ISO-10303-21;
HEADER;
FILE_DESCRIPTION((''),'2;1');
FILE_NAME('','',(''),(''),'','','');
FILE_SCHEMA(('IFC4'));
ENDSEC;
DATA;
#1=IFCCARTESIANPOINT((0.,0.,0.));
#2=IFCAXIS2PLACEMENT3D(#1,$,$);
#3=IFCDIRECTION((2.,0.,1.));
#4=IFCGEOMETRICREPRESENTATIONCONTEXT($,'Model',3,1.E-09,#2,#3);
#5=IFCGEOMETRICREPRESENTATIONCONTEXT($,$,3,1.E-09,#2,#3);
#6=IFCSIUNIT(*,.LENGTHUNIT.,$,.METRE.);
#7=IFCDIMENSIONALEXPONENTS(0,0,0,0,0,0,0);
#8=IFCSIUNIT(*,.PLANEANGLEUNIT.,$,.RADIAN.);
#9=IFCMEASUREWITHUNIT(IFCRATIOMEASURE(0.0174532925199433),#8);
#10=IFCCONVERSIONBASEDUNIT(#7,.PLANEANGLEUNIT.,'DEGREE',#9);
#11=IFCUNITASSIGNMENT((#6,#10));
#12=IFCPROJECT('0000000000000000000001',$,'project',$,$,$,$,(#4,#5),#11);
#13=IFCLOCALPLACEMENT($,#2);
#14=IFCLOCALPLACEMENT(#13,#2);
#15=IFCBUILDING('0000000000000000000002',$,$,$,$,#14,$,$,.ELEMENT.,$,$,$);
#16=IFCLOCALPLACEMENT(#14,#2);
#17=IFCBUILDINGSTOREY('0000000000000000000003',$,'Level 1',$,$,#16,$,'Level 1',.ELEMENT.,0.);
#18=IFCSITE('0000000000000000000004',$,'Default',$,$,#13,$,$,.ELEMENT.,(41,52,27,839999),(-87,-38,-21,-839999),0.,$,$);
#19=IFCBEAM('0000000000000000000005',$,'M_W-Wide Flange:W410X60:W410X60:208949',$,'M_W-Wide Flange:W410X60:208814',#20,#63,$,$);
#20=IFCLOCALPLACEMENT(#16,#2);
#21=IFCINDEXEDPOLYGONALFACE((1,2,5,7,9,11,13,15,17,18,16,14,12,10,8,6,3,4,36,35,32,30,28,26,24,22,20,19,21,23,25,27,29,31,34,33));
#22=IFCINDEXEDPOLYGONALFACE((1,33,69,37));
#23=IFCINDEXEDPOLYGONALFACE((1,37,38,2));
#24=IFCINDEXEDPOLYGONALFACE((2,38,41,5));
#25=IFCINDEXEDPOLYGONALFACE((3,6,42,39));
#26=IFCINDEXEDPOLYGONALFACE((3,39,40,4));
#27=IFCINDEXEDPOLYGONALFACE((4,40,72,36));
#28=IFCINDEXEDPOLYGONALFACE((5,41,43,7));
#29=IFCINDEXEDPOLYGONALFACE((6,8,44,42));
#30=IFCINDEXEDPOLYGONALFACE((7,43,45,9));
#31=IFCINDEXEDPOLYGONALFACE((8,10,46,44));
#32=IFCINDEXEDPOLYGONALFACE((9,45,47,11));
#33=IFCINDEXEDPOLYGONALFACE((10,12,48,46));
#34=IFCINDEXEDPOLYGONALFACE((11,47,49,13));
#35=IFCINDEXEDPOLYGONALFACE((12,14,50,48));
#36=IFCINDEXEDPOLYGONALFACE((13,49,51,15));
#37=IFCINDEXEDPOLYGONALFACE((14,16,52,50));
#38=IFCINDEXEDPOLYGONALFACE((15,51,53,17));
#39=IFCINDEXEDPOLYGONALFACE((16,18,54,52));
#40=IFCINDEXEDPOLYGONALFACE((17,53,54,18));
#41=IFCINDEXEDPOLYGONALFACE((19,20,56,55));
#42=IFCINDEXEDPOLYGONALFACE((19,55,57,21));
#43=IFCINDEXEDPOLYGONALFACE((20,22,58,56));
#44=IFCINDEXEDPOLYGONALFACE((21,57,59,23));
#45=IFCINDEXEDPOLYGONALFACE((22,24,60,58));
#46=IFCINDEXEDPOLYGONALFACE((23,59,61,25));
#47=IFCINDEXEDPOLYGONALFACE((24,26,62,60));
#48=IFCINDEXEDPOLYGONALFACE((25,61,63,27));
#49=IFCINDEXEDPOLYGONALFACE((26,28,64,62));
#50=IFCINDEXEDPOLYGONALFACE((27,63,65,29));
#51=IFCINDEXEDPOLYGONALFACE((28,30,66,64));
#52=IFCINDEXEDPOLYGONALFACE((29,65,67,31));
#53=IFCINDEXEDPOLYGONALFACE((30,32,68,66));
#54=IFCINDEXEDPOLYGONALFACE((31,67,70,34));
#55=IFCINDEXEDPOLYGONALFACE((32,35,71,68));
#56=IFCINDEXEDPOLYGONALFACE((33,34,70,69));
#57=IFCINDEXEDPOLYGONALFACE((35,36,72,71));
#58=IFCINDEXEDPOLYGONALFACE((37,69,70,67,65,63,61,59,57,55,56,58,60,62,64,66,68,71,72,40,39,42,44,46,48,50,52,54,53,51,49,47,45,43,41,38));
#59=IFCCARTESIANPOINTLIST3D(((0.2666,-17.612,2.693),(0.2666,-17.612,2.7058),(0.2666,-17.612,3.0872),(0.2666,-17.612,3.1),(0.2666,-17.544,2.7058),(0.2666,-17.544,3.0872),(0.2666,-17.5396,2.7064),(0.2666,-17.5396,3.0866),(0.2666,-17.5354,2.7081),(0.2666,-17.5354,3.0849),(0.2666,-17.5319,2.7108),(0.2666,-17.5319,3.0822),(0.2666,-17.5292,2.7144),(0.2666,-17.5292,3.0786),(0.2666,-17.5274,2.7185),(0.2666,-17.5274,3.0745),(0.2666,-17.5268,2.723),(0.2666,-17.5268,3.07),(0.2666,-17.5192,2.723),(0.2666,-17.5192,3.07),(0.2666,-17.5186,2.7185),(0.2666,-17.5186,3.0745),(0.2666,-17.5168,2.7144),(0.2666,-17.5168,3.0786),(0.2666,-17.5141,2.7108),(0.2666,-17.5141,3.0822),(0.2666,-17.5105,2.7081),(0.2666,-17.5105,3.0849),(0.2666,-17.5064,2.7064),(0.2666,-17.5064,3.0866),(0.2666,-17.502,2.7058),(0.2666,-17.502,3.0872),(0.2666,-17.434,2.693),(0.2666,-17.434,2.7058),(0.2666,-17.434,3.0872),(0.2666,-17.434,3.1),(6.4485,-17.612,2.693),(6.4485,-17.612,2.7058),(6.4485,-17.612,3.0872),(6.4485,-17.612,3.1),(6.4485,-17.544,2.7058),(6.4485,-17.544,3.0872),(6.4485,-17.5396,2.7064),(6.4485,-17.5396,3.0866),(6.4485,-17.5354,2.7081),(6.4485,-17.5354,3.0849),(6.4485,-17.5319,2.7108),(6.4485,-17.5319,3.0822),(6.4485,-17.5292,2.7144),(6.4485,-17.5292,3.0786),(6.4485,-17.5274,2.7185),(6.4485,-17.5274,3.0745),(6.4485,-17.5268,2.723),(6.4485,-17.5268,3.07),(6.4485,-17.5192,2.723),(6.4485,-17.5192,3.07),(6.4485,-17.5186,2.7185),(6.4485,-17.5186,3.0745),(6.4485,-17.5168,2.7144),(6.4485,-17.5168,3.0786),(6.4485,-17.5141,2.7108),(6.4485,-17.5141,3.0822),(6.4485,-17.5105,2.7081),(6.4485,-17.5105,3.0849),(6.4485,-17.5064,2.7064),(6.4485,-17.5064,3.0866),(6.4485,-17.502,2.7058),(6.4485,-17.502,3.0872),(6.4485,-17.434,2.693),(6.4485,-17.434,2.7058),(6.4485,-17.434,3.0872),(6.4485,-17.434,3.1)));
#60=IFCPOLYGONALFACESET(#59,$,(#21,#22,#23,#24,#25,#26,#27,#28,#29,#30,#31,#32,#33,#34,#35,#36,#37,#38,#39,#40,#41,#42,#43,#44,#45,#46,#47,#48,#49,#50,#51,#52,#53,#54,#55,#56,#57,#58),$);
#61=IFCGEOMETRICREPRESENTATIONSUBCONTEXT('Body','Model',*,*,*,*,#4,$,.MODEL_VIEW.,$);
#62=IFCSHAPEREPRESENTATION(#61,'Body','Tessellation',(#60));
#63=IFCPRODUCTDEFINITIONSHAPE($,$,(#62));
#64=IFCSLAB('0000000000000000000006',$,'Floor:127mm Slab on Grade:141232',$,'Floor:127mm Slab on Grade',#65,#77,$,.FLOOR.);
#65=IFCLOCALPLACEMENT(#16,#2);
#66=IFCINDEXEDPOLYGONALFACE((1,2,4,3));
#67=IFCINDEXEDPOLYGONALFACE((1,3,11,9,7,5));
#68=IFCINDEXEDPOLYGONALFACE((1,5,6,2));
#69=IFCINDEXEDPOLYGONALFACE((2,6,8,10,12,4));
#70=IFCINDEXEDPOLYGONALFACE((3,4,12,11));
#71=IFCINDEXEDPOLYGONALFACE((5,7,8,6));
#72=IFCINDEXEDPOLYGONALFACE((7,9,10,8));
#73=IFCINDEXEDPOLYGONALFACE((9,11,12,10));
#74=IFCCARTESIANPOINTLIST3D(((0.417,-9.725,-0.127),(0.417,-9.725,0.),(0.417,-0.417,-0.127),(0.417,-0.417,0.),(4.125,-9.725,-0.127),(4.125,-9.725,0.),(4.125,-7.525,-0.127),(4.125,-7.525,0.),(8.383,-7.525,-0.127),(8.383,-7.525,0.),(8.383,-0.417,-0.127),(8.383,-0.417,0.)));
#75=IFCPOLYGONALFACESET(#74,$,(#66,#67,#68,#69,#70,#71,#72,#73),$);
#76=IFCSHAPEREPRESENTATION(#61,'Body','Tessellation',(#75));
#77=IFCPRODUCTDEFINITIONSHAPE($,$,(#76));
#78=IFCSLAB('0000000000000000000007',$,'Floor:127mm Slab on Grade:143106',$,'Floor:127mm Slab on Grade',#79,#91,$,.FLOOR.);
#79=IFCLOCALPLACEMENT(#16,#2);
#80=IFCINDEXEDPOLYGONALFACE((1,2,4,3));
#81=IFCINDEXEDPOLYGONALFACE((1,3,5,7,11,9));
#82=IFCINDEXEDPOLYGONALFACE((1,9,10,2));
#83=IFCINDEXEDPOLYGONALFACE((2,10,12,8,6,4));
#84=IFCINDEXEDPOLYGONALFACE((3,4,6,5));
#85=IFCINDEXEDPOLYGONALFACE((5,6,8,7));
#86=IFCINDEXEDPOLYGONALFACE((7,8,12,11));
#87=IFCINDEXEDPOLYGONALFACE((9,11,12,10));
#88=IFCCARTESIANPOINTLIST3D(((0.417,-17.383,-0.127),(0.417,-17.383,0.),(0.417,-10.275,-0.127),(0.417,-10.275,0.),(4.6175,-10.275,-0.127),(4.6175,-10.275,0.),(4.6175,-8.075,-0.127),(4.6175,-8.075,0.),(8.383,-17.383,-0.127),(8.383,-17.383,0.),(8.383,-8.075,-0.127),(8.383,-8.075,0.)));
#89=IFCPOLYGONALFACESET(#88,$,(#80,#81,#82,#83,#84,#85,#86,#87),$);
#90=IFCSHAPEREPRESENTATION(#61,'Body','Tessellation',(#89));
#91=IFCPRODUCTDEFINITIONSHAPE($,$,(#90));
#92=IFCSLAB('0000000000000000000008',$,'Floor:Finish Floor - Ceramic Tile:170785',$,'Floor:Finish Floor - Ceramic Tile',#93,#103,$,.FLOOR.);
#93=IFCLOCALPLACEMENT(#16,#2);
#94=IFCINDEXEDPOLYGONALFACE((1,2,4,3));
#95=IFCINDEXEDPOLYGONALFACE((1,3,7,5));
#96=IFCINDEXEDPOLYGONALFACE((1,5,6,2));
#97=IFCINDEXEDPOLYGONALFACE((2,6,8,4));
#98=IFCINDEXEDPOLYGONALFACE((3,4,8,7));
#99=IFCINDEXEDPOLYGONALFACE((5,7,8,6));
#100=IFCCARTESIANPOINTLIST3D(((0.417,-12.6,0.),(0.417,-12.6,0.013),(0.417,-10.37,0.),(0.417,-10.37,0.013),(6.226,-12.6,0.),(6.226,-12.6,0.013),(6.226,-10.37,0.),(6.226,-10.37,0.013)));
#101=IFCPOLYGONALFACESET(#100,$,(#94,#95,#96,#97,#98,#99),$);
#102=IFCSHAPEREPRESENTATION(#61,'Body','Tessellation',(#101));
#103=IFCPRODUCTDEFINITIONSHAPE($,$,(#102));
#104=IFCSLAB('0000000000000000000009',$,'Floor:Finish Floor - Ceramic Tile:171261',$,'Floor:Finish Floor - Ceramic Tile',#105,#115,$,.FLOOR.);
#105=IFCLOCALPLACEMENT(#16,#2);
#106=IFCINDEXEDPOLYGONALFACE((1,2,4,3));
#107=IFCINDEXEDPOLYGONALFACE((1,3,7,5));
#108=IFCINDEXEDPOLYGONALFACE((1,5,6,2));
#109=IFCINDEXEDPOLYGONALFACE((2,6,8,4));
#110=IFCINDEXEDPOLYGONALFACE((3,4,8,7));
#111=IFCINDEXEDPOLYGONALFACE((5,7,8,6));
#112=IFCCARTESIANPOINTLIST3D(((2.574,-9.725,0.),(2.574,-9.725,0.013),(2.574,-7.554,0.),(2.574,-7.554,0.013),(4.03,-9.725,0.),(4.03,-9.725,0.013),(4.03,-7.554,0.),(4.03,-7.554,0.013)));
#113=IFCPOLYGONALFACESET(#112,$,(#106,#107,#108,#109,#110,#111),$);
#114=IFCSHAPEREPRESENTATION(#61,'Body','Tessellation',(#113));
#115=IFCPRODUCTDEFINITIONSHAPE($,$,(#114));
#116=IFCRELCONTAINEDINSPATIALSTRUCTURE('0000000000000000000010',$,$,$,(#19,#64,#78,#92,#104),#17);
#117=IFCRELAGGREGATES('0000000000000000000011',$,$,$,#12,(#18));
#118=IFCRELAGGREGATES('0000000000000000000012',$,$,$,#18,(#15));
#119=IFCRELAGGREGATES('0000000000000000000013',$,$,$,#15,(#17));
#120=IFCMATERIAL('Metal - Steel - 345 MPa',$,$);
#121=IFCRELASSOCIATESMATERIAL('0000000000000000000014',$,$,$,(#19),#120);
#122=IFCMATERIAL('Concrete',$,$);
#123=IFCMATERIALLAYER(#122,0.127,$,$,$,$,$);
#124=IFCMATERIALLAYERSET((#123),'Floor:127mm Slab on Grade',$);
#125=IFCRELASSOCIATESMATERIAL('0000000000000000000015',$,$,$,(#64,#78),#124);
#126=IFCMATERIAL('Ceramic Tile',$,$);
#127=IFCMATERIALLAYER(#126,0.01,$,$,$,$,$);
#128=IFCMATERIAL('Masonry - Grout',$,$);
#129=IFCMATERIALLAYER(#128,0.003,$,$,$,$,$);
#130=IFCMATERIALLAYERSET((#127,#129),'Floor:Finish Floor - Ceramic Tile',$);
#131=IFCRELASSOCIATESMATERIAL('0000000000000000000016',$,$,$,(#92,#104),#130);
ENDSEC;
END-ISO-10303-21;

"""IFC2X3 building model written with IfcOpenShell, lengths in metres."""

from ifc_helpers import new_model, entity, si_unit, converted_unit, direction, frame, frame_2d, origin, place, context, subcontext, project, spatial, polyline, rectangle, i_section, outline, extrude, material, layer, layer_set, layer_usage, element, save


model = new_model("IFC2X3")

# Units and contexts
model_context = context("Model", 3, precision=1e-09, world=origin(), true_north=direction((2.0, 0.0, 1.0)))
context_of_model = context(None, 3, precision=1e-09, world=origin(), true_north=direction((2.0, 0.0, 1.0)))
body_context = subcontext(model_context, "Body", "Model", "MODEL_VIEW")
ifc_project = project(units=[si_unit("LENGTHUNIT", "METRE"), converted_unit("PLANEANGLEUNIT", "DEGREE", entity("IfcRatioMeasure", 0.0174532925199433), si_unit("PLANEANGLEUNIT", "RADIAN"), dimensions=[0, 0, 0, 0, 0, 0, 0])], contexts=[model_context, context_of_model])

# Site, building, storey
site_placement = place(None, origin())
site = spatial("IfcSite", under=ifc_project, at=site_placement, Name="Default", CompositionType="ELEMENT", RefLatitude=(41, 52, 27, 839999), RefLongitude=(-87, -38, -21, -839999), RefElevation=0.0)
building_placement = place(site_placement, origin())
building = spatial("IfcBuilding", under=site, at=building_placement, CompositionType="ELEMENT")
storey_placement = place(building_placement, origin())
storey = spatial("IfcBuildingStorey", under=building, at=storey_placement, Name="Level 1", LongName="Level 1", CompositionType="ELEMENT", Elevation=0.0)

# Beam
ifc_material_1 = material(Name="Metal - Steel - 345 MPa")
beam_placement = place(storey_placement, frame((0.2085, -17.523, 3.1)))
element("IfcBeam", 1, at=beam_placement, inside=storey, material=ifc_material_1, Name="M_W-Wide Flange:W410X60:W410X60:208949", ObjectType="M_W-Wide Flange:W410X60:208814", context=body_context, shape_type="SweptSolid", body=[
    extrude(i_section(OverallWidth=0.178, OverallDepth=0.407, WebThickness=0.0077, FlangeThickness=0.0128, FilletRadius=0.0172, at=frame_2d((0.0, 0.0), x_axis=(1.0, 0.0))), frame((0.0581, 0.0, -0.2035), z_axis=(-1.0, 0.0, 0.0), x_axis=(0.0, -1.0, 0.0)), (0.0, 0.0, -1.0), 6.1819),
])

# Slabs
ifc_material_2 = material(Name="Concrete")
ifc_layer_1 = layer(ifc_material_2, 0.127)
ifc_layer_set_1 = layer_set([ifc_layer_1], Name="Floor:127mm Slab on Grade")
ifc_layer_usage_1 = layer_usage(ifc_layer_set_1, "AXIS3", "POSITIVE", 0.0)
slab_1_placement = place(storey_placement, frame((0.417, -9.725, -0.127)))
element("IfcSlab", 2, at=slab_1_placement, inside=storey, material=ifc_layer_usage_1, Name="Floor:127mm Slab on Grade:141232", ObjectType="Floor:127mm Slab on Grade", PredefinedType="FLOOR", context=body_context, shape_type="SweptSolid", body=[
    extrude(outline(polyline([(-3.983, 4.654), (-3.983, -2.454), (0.275, -2.454), (0.275, -4.654), (3.983, -4.654), (3.983, 4.654), (-3.983, 4.654)])), frame((3.983, 4.654, 0.127), z_axis=(0.0, 0.0, -1.0), x_axis=(-1.0, 0.0, 0.0)), (0.0, 0.0, 1.0), 0.127),
])
ifc_layer_usage_2 = layer_usage(ifc_layer_set_1, "AXIS3", "POSITIVE", 0.0)
slab_2_placement = place(storey_placement, frame((0.417, -17.383, -0.127)))
element("IfcSlab", 3, at=slab_2_placement, inside=storey, material=ifc_layer_usage_2, Name="Floor:127mm Slab on Grade:143106", ObjectType="Floor:127mm Slab on Grade", PredefinedType="FLOOR", context=body_context, shape_type="SweptSolid", body=[
    extrude(outline(polyline([(-3.983, 4.654), (-3.983, -4.654), (3.983, -4.654), (3.983, 2.454), (-0.2175, 2.454), (-0.2175, 4.654), (-3.983, 4.654)])), frame((3.983, 4.654, 0.127), z_axis=(0.0, 0.0, -1.0), x_axis=(-1.0, 0.0, 0.0)), (0.0, 0.0, 1.0), 0.127),
])
ifc_material_3 = material(Name="Ceramic Tile")
ifc_layer_2 = layer(ifc_material_3, 0.01)
ifc_material_4 = material(Name="Masonry - Grout")
ifc_layer_3 = layer(ifc_material_4, 0.003)
ifc_layer_set_2 = layer_set([ifc_layer_2, ifc_layer_3], Name="Floor:Finish Floor - Ceramic Tile")
ifc_layer_usage_3 = layer_usage(ifc_layer_set_2, "AXIS3", "POSITIVE", 0.0)
slab_3_placement = place(storey_placement, frame((0.417, -12.6, 0.0)))
element("IfcSlab", 4, at=slab_3_placement, inside=storey, material=ifc_layer_usage_3, Name="Floor:Finish Floor - Ceramic Tile:170785", ObjectType="Floor:Finish Floor - Ceramic Tile", PredefinedType="FLOOR", context=body_context, shape_type="SweptSolid", body=[
    extrude(rectangle(XDim=5.809, YDim=2.23, at=frame_2d((0.0, 0.0), x_axis=(-1.0, 0.0))), frame((2.9045, 1.115, 0.013), z_axis=(0.0, 0.0, -1.0), x_axis=(-1.0, 0.0, 0.0)), (0.0, 0.0, 1.0), 0.013),
])
ifc_layer_usage_4 = layer_usage(ifc_layer_set_2, "AXIS3", "POSITIVE", 0.0)
slab_4_placement = place(storey_placement, frame((2.574, -9.725, 0.0)))
element("IfcSlab", 5, at=slab_4_placement, inside=storey, material=ifc_layer_usage_4, Name="Floor:Finish Floor - Ceramic Tile:171261", ObjectType="Floor:Finish Floor - Ceramic Tile", PredefinedType="FLOOR", context=body_context, shape_type="SweptSolid", body=[
    extrude(rectangle(XDim=2.171, YDim=1.456, at=frame_2d((0.0, 0.0), x_axis=(0.0, -1.0))), frame((0.728, 1.0855, 0.013), z_axis=(0.0, 0.0, -1.0), x_axis=(-1.0, 0.0, 0.0)), (0.0, 0.0, 1.0), 0.013),
])

save(model, "model.ifc")
